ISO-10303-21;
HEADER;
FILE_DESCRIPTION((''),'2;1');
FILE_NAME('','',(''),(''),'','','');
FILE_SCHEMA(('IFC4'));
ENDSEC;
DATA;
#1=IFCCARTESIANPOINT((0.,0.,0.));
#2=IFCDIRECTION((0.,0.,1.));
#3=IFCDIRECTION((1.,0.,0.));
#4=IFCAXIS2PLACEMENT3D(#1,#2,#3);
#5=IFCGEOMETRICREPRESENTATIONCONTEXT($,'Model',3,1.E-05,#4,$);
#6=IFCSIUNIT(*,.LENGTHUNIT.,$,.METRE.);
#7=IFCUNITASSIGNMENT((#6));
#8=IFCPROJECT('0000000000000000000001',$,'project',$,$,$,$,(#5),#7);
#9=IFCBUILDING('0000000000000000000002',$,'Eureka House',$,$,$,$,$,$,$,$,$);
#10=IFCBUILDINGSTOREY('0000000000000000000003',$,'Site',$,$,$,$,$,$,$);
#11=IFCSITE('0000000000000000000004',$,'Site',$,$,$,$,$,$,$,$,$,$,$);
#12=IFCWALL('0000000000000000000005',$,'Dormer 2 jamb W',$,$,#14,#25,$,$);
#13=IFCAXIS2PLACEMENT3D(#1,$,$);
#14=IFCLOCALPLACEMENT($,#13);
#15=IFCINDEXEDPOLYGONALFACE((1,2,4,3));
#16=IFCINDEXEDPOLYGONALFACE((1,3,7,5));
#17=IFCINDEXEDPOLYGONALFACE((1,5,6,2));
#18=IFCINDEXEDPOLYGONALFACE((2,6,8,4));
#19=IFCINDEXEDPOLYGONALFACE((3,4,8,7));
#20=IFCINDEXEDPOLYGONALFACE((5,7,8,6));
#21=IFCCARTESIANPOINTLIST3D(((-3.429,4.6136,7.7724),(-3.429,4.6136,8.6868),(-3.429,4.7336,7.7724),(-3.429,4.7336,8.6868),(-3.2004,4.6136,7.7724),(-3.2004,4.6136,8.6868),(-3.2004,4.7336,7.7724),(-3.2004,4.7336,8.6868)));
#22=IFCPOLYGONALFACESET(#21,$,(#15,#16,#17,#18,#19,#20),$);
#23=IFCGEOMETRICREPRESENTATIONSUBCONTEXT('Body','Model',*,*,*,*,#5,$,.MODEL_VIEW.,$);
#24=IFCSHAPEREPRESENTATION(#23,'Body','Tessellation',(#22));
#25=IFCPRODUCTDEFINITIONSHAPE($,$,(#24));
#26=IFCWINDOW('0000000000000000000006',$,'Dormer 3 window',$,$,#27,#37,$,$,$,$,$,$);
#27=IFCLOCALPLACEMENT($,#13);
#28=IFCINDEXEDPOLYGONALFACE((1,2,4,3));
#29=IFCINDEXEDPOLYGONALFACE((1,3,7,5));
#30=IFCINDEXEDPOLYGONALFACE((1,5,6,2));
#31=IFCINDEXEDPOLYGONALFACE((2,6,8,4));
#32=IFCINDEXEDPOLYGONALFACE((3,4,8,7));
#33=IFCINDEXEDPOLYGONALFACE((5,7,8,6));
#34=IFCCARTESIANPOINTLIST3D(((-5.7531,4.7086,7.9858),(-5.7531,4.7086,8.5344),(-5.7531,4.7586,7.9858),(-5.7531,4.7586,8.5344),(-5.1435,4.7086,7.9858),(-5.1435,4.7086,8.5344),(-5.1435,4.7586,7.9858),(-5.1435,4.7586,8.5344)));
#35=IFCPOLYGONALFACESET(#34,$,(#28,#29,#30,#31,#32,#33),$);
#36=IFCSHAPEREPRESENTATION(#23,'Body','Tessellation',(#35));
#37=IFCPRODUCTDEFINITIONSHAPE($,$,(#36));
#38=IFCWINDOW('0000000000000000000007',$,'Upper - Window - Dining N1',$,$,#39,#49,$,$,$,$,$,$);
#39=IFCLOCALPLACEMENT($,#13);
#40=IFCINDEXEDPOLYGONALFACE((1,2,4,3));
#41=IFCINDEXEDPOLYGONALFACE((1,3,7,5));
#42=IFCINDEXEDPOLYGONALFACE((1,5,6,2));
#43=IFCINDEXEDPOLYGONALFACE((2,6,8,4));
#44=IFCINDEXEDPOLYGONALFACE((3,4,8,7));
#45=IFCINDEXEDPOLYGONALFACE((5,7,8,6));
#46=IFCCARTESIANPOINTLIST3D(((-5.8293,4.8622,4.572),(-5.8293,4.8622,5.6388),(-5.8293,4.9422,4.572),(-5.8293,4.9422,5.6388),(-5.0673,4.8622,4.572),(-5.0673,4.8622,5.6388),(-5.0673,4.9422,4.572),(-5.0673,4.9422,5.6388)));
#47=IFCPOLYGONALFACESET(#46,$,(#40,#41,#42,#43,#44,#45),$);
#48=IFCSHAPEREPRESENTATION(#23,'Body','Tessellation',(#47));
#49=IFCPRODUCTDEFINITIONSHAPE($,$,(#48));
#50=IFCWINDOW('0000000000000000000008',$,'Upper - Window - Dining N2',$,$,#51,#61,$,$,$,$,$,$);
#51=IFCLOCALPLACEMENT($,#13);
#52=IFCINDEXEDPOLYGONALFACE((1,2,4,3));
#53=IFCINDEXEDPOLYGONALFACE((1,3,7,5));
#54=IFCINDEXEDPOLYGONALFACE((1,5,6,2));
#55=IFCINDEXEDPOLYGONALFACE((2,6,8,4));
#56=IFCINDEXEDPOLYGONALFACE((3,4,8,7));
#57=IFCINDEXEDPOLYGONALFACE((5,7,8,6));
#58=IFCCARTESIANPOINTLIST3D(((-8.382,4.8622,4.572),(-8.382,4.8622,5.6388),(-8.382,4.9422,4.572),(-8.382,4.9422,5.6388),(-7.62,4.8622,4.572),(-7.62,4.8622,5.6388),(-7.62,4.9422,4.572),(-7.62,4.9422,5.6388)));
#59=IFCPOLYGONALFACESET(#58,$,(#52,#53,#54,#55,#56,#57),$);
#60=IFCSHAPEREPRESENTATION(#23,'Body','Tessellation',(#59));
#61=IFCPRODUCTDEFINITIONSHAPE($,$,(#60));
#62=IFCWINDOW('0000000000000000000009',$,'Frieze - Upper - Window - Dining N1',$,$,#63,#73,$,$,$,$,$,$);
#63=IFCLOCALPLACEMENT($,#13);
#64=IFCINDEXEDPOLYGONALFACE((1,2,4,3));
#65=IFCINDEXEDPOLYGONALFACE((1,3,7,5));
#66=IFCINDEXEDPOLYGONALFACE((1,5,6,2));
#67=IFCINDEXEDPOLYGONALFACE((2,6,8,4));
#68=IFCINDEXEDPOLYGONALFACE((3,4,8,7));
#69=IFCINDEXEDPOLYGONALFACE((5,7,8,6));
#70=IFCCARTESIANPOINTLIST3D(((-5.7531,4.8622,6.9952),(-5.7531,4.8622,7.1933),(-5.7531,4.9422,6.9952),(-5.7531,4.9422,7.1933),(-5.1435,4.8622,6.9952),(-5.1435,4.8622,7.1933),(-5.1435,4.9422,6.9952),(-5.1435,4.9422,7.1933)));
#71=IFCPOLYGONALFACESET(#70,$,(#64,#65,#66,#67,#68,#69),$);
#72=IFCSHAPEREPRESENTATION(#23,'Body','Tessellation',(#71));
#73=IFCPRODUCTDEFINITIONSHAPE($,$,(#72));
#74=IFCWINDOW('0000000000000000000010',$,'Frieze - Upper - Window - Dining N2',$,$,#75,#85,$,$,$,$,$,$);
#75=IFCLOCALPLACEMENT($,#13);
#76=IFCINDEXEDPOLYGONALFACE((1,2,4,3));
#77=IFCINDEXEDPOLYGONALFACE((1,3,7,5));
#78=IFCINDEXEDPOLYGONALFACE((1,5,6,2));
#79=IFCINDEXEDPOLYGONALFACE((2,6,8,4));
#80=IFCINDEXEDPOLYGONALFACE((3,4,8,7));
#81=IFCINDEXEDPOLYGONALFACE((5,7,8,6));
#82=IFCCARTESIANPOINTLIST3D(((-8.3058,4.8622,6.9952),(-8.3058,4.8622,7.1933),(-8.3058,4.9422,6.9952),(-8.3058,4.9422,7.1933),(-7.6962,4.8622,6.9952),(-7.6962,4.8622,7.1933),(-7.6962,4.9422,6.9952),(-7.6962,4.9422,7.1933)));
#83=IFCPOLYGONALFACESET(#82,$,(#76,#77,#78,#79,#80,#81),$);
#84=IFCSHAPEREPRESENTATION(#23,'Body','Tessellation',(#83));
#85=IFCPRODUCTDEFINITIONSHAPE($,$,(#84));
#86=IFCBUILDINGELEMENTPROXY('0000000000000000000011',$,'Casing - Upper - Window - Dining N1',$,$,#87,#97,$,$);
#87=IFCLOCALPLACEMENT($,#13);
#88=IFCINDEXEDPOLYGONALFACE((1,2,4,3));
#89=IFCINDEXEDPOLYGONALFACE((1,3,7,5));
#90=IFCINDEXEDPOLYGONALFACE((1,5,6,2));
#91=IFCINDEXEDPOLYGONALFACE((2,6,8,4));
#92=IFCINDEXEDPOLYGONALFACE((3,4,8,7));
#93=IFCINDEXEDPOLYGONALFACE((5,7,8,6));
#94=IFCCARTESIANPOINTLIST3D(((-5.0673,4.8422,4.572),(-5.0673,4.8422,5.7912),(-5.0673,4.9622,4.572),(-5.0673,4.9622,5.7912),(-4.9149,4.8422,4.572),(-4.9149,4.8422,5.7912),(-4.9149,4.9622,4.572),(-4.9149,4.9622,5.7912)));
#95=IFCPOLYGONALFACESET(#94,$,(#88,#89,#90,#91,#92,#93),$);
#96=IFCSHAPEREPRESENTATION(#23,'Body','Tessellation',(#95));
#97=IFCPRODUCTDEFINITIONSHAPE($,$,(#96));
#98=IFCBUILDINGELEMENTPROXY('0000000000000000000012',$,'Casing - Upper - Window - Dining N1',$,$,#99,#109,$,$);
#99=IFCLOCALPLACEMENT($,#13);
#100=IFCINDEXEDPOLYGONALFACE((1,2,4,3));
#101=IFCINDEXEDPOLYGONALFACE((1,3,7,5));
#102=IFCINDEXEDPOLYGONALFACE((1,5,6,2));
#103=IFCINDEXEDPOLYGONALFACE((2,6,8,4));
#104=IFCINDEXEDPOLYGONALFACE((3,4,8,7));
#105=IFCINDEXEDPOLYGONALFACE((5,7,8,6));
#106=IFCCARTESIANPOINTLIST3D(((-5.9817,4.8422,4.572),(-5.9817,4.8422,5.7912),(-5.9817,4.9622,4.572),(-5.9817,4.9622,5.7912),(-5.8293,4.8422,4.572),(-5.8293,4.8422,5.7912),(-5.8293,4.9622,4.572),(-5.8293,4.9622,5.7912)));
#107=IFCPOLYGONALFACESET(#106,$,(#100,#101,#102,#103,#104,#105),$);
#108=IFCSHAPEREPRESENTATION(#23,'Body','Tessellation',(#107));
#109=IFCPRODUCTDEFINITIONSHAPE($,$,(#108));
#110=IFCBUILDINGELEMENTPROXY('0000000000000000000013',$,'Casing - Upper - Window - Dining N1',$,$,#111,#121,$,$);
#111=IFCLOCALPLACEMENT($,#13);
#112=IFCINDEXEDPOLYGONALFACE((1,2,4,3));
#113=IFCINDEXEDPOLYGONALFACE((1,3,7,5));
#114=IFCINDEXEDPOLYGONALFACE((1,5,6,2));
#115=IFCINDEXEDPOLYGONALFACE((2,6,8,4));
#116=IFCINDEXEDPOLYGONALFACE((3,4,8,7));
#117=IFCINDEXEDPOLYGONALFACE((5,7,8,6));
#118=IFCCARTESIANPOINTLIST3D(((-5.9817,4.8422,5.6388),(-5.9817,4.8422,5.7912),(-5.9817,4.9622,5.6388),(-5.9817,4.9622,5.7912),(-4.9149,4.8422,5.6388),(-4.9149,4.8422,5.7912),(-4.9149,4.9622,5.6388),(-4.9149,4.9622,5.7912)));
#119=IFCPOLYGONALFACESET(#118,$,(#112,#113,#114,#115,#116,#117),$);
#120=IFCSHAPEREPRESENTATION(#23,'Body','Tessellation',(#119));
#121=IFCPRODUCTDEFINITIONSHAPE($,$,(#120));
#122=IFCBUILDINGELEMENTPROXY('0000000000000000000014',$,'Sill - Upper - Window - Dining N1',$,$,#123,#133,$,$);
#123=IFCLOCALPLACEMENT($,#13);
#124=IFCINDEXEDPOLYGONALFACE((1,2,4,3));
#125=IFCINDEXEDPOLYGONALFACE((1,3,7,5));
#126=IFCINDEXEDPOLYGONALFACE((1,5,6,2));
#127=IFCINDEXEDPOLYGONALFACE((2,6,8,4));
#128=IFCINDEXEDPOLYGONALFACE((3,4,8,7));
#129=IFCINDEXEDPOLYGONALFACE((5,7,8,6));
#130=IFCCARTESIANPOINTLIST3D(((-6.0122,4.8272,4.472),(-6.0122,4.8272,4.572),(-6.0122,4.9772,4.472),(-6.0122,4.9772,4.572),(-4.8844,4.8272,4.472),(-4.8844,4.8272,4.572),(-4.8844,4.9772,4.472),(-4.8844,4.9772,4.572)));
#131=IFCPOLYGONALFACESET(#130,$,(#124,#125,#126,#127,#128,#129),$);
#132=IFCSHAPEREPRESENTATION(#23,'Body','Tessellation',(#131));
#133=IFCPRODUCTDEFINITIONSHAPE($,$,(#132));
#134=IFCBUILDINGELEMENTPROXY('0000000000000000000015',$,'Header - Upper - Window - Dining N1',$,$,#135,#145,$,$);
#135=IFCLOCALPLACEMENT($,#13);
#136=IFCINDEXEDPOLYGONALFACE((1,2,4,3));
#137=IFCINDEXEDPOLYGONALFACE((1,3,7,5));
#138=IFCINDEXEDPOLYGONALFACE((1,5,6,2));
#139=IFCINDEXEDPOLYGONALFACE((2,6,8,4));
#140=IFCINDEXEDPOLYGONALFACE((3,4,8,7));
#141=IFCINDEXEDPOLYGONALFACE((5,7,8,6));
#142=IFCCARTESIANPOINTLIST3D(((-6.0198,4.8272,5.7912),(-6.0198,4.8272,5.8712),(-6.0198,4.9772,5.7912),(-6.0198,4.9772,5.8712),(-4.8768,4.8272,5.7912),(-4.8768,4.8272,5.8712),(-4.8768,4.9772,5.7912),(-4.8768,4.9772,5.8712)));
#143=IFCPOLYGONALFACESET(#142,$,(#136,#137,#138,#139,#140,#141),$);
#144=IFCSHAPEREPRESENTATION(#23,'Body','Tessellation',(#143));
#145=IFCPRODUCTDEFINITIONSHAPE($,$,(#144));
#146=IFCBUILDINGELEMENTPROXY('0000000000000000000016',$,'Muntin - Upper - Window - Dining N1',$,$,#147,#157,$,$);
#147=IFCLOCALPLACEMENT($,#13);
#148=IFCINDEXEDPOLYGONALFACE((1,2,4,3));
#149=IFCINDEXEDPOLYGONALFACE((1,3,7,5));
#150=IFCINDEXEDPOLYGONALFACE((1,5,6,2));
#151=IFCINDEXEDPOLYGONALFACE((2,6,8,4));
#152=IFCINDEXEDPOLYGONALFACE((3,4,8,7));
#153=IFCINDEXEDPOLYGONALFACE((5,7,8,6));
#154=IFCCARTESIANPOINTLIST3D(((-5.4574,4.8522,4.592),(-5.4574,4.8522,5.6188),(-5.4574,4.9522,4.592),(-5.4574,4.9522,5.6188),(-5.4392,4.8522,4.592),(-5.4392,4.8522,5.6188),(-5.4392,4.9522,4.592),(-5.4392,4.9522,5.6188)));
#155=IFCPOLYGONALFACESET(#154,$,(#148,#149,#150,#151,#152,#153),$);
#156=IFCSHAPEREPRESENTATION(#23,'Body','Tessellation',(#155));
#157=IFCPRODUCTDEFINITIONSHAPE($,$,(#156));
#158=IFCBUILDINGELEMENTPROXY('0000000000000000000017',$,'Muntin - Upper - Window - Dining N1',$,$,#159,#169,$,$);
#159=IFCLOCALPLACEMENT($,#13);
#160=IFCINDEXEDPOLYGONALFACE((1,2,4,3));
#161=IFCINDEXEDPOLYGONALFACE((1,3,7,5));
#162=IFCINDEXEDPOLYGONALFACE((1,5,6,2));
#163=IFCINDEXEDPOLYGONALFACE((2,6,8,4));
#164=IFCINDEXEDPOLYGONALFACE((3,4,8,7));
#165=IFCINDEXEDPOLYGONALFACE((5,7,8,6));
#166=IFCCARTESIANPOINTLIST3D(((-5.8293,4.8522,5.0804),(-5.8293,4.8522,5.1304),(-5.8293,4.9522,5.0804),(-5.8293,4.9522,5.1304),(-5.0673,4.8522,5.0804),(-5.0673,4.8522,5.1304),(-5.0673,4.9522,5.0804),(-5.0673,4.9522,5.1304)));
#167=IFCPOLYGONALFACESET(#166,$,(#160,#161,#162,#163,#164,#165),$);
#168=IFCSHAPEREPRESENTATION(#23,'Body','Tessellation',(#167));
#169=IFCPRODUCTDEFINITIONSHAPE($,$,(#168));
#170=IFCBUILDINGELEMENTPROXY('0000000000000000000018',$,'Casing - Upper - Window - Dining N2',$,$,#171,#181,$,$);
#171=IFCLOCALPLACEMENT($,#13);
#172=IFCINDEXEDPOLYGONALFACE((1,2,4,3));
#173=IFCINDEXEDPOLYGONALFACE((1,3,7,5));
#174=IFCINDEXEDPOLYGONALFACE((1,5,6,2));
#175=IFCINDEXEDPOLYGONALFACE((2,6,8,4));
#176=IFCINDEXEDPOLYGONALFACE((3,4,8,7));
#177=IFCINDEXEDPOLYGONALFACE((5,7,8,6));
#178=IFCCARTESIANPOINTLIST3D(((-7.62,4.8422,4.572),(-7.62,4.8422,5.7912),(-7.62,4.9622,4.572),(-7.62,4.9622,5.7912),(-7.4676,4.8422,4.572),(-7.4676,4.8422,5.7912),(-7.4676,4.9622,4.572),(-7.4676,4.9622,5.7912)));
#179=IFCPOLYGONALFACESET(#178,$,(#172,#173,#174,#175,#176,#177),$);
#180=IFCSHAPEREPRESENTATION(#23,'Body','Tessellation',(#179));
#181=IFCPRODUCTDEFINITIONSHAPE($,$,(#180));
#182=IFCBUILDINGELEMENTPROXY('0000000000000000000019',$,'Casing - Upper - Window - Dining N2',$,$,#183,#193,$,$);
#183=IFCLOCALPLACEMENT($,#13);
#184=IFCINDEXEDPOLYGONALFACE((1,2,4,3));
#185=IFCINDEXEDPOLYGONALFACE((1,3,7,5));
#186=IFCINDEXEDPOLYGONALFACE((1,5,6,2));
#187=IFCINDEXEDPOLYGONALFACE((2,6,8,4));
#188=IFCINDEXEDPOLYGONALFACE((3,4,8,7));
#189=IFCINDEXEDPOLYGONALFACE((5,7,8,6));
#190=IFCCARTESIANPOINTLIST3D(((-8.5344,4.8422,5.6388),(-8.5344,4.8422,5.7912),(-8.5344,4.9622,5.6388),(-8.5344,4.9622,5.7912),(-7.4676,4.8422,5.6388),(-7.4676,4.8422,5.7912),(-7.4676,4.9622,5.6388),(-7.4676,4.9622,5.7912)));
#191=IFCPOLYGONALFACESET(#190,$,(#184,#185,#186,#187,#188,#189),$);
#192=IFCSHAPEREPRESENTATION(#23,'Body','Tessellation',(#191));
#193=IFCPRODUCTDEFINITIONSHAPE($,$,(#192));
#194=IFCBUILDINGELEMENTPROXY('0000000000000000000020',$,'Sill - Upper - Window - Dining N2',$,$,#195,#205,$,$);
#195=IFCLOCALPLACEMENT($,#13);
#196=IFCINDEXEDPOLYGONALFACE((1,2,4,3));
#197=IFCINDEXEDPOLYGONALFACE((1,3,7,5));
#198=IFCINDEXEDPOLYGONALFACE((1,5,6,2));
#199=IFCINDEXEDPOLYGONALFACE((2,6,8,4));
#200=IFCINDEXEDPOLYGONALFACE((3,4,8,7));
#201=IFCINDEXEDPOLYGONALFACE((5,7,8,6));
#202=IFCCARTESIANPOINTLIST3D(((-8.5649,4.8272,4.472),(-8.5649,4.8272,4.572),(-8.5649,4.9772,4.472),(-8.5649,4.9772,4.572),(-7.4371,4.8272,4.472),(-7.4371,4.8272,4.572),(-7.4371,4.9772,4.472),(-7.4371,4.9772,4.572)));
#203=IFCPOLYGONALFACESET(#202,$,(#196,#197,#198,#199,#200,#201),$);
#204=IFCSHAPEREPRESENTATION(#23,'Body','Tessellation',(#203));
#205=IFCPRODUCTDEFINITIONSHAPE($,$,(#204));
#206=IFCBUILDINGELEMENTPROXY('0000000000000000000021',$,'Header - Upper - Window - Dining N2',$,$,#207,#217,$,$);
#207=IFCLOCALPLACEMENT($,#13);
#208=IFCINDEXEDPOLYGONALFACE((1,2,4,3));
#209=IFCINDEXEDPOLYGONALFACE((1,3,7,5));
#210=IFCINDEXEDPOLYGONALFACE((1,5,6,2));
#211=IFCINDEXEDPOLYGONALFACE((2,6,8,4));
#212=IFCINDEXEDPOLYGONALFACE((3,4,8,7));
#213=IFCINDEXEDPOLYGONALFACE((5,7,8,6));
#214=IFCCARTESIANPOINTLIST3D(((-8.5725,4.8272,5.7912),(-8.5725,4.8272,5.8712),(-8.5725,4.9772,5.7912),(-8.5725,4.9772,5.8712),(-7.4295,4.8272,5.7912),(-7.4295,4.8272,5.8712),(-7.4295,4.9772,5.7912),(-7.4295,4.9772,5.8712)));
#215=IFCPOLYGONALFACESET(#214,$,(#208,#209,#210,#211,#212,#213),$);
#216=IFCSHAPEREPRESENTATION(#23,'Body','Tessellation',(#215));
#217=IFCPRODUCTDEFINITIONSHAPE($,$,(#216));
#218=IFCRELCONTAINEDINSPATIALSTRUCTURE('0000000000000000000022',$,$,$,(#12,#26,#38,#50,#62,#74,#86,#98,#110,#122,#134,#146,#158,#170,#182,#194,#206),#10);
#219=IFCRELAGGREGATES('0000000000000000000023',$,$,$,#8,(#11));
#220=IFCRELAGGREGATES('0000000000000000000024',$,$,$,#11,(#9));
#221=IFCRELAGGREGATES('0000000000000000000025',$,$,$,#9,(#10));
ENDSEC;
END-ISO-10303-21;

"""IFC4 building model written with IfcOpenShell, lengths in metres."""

from ifc_helpers import new_model, si_unit, frame, origin, origin_with_axes, origin_2d, place, context, subcontext, project, spatial, rectangle, extrude, element, save


model = new_model("IFC4")

# Units and contexts
model_context = context("Model", 3, precision=1e-05, world=origin_with_axes())
body_context = subcontext(model_context, "Body", "Model", "MODEL_VIEW")
ifc_project = project(units=[si_unit("LENGTHUNIT", "METRE")], contexts=[model_context])

# Site, building, storey
site = spatial("IfcSite", under=ifc_project, Name="Site")
building = spatial("IfcBuilding", under=site, Name="Eureka House")
storey = spatial("IfcBuildingStorey", under=building, Name="Site")

# Wall
wall_placement = place(None, frame((-3.3147, 4.6736, 7.7724), z_axis=(0.0, 0.0, 1.0), x_axis=(1.0, 0.0, 0.0)))
element("IfcWall", 1, at=wall_placement, inside=storey, Name="Dormer 2 jamb W", context=body_context, shape_type="SweptSolid", body=[
    extrude(rectangle(XDim=0.2286, YDim=0.12, at=origin_2d()), origin(), (0.0, 0.0, 1.0), 0.9144),
])

# Windows
window_placement = place(None, frame((-5.4483, 4.7336, 7.9858), z_axis=(0.0, 0.0, 1.0), x_axis=(1.0, 0.0, 0.0)))
element("IfcWindow", 2, at=window_placement, inside=storey, Name="Dormer 3 window", context=body_context, shape_type="SweptSolid", body=[
    extrude(rectangle(XDim=0.6096, YDim=0.05, at=origin_2d()), origin(), (0.0, 0.0, 1.0), 0.5486),
])
for number, where, z_axis, x_axis, name in (
    (3, (-5.4483, 4.9022, 4.572), (0.0, 0.0, 1.0), (1.0, 0.0, 0.0), "Upper - Window - Dining N1"),
    (4, (-8.001, 4.9022, 4.572), (0.0, 0.0, 1.0), (1.0, 0.0, 0.0), "Upper - Window - Dining N2"),
):
    element("IfcWindow", number, at=place(None, frame(where, z_axis=z_axis, x_axis=x_axis)), inside=storey, Name=name, context=body_context, shape_type="SweptSolid", body=[
        extrude(rectangle(XDim=0.762, YDim=0.08, at=origin_2d()), origin(), (0.0, 0.0, 1.0), 1.0668),
    ])
for number, where, z_axis, x_axis, name in (
    (5, (-5.4483, 4.9022, 6.9952), (0.0, 0.0, 1.0), (1.0, 0.0, 0.0), "Frieze - Upper - Window - Dining N1"),
    (6, (-8.001, 4.9022, 6.9952), (0.0, 0.0, 1.0), (1.0, 0.0, 0.0), "Frieze - Upper - Window - Dining N2"),
):
    element("IfcWindow", number, at=place(None, frame(where, z_axis=z_axis, x_axis=x_axis)), inside=storey, Name=name, context=body_context, shape_type="SweptSolid", body=[
        extrude(rectangle(XDim=0.6096, YDim=0.08, at=origin_2d()), origin(), (0.0, 0.0, 1.0), 0.1981),
    ])

# Building element proxies
for number, where, z_axis, x_axis, name in (
    (7, (-4.9911, 4.9022, 4.572), (0.0, 0.0, 1.0), (1.0, 0.0, 0.0), "Casing - Upper - Window - Dining N1"),
    (8, (-5.9055, 4.9022, 4.572), (0.0, 0.0, 1.0), (1.0, 0.0, 0.0), "Casing - Upper - Window - Dining N1"),
):
    element("IfcBuildingElementProxy", number, at=place(None, frame(where, z_axis=z_axis, x_axis=x_axis)), inside=storey, Name=name, context=body_context, shape_type="SweptSolid", body=[
        extrude(rectangle(XDim=0.1524, YDim=0.12, at=origin_2d()), origin(), (0.0, 0.0, 1.0), 1.2192),
    ])
proxy_1_placement = place(None, frame((-5.4483, 4.9022, 5.6388), z_axis=(0.0, 0.0, 1.0), x_axis=(1.0, 0.0, 0.0)))
element("IfcBuildingElementProxy", 9, at=proxy_1_placement, inside=storey, Name="Casing - Upper - Window - Dining N1", context=body_context, shape_type="SweptSolid", body=[
    extrude(rectangle(XDim=1.0668, YDim=0.12, at=origin_2d()), origin(), (0.0, 0.0, 1.0), 0.1524),
])
proxy_2_placement = place(None, frame((-5.4483, 4.9022, 4.472), z_axis=(0.0, 0.0, 1.0), x_axis=(1.0, 0.0, 0.0)))
element("IfcBuildingElementProxy", 10, at=proxy_2_placement, inside=storey, Name="Sill - Upper - Window - Dining N1", context=body_context, shape_type="SweptSolid", body=[
    extrude(rectangle(XDim=1.1278, YDim=0.15, at=origin_2d()), origin(), (0.0, 0.0, 1.0), 0.1),
])
proxy_3_placement = place(None, frame((-5.4483, 4.9022, 5.7912), z_axis=(0.0, 0.0, 1.0), x_axis=(1.0, 0.0, 0.0)))
element("IfcBuildingElementProxy", 11, at=proxy_3_placement, inside=storey, Name="Header - Upper - Window - Dining N1", context=body_context, shape_type="SweptSolid", body=[
    extrude(rectangle(XDim=1.143, YDim=0.15, at=origin_2d()), origin(), (0.0, 0.0, 1.0), 0.08),
])
proxy_4_placement = place(None, frame((-5.4483, 4.9022, 4.592), z_axis=(0.0, 0.0, 1.0), x_axis=(1.0, 0.0, 0.0)))
element("IfcBuildingElementProxy", 12, at=proxy_4_placement, inside=storey, Name="Muntin - Upper - Window - Dining N1", context=body_context, shape_type="SweptSolid", body=[
    extrude(rectangle(XDim=0.0183, YDim=0.1, at=origin_2d()), origin(), (0.0, 0.0, 1.0), 1.0268),
])
proxy_5_placement = place(None, frame((-5.4483, 4.9022, 5.0804), z_axis=(0.0, 0.0, 1.0), x_axis=(1.0, 0.0, 0.0)))
element("IfcBuildingElementProxy", 13, at=proxy_5_placement, inside=storey, Name="Muntin - Upper - Window - Dining N1", context=body_context, shape_type="SweptSolid", body=[
    extrude(rectangle(XDim=0.762, YDim=0.1, at=origin_2d()), origin(), (0.0, 0.0, 1.0), 0.05),
])
proxy_6_placement = place(None, frame((-7.5438, 4.9022, 4.572), z_axis=(0.0, 0.0, 1.0), x_axis=(1.0, 0.0, 0.0)))
element("IfcBuildingElementProxy", 14, at=proxy_6_placement, inside=storey, Name="Casing - Upper - Window - Dining N2", context=body_context, shape_type="SweptSolid", body=[
    extrude(rectangle(XDim=0.1524, YDim=0.12, at=origin_2d()), origin(), (0.0, 0.0, 1.0), 1.2192),
])
proxy_7_placement = place(None, frame((-8.001, 4.9022, 5.6388), z_axis=(0.0, 0.0, 1.0), x_axis=(1.0, 0.0, 0.0)))
element("IfcBuildingElementProxy", 15, at=proxy_7_placement, inside=storey, Name="Casing - Upper - Window - Dining N2", context=body_context, shape_type="SweptSolid", body=[
    extrude(rectangle(XDim=1.0668, YDim=0.12, at=origin_2d()), origin(), (0.0, 0.0, 1.0), 0.1524),
])
proxy_8_placement = place(None, frame((-8.001, 4.9022, 4.472), z_axis=(0.0, 0.0, 1.0), x_axis=(1.0, 0.0, 0.0)))
element("IfcBuildingElementProxy", 16, at=proxy_8_placement, inside=storey, Name="Sill - Upper - Window - Dining N2", context=body_context, shape_type="SweptSolid", body=[
    extrude(rectangle(XDim=1.1278, YDim=0.15, at=origin_2d()), origin(), (0.0, 0.0, 1.0), 0.1),
])
proxy_9_placement = place(None, frame((-8.001, 4.9022, 5.7912), z_axis=(0.0, 0.0, 1.0), x_axis=(1.0, 0.0, 0.0)))
element("IfcBuildingElementProxy", 17, at=proxy_9_placement, inside=storey, Name="Header - Upper - Window - Dining N2", context=body_context, shape_type="SweptSolid", body=[
    extrude(rectangle(XDim=1.143, YDim=0.15, at=origin_2d()), origin(), (0.0, 0.0, 1.0), 0.08),
])

save(model, "model.ifc")
